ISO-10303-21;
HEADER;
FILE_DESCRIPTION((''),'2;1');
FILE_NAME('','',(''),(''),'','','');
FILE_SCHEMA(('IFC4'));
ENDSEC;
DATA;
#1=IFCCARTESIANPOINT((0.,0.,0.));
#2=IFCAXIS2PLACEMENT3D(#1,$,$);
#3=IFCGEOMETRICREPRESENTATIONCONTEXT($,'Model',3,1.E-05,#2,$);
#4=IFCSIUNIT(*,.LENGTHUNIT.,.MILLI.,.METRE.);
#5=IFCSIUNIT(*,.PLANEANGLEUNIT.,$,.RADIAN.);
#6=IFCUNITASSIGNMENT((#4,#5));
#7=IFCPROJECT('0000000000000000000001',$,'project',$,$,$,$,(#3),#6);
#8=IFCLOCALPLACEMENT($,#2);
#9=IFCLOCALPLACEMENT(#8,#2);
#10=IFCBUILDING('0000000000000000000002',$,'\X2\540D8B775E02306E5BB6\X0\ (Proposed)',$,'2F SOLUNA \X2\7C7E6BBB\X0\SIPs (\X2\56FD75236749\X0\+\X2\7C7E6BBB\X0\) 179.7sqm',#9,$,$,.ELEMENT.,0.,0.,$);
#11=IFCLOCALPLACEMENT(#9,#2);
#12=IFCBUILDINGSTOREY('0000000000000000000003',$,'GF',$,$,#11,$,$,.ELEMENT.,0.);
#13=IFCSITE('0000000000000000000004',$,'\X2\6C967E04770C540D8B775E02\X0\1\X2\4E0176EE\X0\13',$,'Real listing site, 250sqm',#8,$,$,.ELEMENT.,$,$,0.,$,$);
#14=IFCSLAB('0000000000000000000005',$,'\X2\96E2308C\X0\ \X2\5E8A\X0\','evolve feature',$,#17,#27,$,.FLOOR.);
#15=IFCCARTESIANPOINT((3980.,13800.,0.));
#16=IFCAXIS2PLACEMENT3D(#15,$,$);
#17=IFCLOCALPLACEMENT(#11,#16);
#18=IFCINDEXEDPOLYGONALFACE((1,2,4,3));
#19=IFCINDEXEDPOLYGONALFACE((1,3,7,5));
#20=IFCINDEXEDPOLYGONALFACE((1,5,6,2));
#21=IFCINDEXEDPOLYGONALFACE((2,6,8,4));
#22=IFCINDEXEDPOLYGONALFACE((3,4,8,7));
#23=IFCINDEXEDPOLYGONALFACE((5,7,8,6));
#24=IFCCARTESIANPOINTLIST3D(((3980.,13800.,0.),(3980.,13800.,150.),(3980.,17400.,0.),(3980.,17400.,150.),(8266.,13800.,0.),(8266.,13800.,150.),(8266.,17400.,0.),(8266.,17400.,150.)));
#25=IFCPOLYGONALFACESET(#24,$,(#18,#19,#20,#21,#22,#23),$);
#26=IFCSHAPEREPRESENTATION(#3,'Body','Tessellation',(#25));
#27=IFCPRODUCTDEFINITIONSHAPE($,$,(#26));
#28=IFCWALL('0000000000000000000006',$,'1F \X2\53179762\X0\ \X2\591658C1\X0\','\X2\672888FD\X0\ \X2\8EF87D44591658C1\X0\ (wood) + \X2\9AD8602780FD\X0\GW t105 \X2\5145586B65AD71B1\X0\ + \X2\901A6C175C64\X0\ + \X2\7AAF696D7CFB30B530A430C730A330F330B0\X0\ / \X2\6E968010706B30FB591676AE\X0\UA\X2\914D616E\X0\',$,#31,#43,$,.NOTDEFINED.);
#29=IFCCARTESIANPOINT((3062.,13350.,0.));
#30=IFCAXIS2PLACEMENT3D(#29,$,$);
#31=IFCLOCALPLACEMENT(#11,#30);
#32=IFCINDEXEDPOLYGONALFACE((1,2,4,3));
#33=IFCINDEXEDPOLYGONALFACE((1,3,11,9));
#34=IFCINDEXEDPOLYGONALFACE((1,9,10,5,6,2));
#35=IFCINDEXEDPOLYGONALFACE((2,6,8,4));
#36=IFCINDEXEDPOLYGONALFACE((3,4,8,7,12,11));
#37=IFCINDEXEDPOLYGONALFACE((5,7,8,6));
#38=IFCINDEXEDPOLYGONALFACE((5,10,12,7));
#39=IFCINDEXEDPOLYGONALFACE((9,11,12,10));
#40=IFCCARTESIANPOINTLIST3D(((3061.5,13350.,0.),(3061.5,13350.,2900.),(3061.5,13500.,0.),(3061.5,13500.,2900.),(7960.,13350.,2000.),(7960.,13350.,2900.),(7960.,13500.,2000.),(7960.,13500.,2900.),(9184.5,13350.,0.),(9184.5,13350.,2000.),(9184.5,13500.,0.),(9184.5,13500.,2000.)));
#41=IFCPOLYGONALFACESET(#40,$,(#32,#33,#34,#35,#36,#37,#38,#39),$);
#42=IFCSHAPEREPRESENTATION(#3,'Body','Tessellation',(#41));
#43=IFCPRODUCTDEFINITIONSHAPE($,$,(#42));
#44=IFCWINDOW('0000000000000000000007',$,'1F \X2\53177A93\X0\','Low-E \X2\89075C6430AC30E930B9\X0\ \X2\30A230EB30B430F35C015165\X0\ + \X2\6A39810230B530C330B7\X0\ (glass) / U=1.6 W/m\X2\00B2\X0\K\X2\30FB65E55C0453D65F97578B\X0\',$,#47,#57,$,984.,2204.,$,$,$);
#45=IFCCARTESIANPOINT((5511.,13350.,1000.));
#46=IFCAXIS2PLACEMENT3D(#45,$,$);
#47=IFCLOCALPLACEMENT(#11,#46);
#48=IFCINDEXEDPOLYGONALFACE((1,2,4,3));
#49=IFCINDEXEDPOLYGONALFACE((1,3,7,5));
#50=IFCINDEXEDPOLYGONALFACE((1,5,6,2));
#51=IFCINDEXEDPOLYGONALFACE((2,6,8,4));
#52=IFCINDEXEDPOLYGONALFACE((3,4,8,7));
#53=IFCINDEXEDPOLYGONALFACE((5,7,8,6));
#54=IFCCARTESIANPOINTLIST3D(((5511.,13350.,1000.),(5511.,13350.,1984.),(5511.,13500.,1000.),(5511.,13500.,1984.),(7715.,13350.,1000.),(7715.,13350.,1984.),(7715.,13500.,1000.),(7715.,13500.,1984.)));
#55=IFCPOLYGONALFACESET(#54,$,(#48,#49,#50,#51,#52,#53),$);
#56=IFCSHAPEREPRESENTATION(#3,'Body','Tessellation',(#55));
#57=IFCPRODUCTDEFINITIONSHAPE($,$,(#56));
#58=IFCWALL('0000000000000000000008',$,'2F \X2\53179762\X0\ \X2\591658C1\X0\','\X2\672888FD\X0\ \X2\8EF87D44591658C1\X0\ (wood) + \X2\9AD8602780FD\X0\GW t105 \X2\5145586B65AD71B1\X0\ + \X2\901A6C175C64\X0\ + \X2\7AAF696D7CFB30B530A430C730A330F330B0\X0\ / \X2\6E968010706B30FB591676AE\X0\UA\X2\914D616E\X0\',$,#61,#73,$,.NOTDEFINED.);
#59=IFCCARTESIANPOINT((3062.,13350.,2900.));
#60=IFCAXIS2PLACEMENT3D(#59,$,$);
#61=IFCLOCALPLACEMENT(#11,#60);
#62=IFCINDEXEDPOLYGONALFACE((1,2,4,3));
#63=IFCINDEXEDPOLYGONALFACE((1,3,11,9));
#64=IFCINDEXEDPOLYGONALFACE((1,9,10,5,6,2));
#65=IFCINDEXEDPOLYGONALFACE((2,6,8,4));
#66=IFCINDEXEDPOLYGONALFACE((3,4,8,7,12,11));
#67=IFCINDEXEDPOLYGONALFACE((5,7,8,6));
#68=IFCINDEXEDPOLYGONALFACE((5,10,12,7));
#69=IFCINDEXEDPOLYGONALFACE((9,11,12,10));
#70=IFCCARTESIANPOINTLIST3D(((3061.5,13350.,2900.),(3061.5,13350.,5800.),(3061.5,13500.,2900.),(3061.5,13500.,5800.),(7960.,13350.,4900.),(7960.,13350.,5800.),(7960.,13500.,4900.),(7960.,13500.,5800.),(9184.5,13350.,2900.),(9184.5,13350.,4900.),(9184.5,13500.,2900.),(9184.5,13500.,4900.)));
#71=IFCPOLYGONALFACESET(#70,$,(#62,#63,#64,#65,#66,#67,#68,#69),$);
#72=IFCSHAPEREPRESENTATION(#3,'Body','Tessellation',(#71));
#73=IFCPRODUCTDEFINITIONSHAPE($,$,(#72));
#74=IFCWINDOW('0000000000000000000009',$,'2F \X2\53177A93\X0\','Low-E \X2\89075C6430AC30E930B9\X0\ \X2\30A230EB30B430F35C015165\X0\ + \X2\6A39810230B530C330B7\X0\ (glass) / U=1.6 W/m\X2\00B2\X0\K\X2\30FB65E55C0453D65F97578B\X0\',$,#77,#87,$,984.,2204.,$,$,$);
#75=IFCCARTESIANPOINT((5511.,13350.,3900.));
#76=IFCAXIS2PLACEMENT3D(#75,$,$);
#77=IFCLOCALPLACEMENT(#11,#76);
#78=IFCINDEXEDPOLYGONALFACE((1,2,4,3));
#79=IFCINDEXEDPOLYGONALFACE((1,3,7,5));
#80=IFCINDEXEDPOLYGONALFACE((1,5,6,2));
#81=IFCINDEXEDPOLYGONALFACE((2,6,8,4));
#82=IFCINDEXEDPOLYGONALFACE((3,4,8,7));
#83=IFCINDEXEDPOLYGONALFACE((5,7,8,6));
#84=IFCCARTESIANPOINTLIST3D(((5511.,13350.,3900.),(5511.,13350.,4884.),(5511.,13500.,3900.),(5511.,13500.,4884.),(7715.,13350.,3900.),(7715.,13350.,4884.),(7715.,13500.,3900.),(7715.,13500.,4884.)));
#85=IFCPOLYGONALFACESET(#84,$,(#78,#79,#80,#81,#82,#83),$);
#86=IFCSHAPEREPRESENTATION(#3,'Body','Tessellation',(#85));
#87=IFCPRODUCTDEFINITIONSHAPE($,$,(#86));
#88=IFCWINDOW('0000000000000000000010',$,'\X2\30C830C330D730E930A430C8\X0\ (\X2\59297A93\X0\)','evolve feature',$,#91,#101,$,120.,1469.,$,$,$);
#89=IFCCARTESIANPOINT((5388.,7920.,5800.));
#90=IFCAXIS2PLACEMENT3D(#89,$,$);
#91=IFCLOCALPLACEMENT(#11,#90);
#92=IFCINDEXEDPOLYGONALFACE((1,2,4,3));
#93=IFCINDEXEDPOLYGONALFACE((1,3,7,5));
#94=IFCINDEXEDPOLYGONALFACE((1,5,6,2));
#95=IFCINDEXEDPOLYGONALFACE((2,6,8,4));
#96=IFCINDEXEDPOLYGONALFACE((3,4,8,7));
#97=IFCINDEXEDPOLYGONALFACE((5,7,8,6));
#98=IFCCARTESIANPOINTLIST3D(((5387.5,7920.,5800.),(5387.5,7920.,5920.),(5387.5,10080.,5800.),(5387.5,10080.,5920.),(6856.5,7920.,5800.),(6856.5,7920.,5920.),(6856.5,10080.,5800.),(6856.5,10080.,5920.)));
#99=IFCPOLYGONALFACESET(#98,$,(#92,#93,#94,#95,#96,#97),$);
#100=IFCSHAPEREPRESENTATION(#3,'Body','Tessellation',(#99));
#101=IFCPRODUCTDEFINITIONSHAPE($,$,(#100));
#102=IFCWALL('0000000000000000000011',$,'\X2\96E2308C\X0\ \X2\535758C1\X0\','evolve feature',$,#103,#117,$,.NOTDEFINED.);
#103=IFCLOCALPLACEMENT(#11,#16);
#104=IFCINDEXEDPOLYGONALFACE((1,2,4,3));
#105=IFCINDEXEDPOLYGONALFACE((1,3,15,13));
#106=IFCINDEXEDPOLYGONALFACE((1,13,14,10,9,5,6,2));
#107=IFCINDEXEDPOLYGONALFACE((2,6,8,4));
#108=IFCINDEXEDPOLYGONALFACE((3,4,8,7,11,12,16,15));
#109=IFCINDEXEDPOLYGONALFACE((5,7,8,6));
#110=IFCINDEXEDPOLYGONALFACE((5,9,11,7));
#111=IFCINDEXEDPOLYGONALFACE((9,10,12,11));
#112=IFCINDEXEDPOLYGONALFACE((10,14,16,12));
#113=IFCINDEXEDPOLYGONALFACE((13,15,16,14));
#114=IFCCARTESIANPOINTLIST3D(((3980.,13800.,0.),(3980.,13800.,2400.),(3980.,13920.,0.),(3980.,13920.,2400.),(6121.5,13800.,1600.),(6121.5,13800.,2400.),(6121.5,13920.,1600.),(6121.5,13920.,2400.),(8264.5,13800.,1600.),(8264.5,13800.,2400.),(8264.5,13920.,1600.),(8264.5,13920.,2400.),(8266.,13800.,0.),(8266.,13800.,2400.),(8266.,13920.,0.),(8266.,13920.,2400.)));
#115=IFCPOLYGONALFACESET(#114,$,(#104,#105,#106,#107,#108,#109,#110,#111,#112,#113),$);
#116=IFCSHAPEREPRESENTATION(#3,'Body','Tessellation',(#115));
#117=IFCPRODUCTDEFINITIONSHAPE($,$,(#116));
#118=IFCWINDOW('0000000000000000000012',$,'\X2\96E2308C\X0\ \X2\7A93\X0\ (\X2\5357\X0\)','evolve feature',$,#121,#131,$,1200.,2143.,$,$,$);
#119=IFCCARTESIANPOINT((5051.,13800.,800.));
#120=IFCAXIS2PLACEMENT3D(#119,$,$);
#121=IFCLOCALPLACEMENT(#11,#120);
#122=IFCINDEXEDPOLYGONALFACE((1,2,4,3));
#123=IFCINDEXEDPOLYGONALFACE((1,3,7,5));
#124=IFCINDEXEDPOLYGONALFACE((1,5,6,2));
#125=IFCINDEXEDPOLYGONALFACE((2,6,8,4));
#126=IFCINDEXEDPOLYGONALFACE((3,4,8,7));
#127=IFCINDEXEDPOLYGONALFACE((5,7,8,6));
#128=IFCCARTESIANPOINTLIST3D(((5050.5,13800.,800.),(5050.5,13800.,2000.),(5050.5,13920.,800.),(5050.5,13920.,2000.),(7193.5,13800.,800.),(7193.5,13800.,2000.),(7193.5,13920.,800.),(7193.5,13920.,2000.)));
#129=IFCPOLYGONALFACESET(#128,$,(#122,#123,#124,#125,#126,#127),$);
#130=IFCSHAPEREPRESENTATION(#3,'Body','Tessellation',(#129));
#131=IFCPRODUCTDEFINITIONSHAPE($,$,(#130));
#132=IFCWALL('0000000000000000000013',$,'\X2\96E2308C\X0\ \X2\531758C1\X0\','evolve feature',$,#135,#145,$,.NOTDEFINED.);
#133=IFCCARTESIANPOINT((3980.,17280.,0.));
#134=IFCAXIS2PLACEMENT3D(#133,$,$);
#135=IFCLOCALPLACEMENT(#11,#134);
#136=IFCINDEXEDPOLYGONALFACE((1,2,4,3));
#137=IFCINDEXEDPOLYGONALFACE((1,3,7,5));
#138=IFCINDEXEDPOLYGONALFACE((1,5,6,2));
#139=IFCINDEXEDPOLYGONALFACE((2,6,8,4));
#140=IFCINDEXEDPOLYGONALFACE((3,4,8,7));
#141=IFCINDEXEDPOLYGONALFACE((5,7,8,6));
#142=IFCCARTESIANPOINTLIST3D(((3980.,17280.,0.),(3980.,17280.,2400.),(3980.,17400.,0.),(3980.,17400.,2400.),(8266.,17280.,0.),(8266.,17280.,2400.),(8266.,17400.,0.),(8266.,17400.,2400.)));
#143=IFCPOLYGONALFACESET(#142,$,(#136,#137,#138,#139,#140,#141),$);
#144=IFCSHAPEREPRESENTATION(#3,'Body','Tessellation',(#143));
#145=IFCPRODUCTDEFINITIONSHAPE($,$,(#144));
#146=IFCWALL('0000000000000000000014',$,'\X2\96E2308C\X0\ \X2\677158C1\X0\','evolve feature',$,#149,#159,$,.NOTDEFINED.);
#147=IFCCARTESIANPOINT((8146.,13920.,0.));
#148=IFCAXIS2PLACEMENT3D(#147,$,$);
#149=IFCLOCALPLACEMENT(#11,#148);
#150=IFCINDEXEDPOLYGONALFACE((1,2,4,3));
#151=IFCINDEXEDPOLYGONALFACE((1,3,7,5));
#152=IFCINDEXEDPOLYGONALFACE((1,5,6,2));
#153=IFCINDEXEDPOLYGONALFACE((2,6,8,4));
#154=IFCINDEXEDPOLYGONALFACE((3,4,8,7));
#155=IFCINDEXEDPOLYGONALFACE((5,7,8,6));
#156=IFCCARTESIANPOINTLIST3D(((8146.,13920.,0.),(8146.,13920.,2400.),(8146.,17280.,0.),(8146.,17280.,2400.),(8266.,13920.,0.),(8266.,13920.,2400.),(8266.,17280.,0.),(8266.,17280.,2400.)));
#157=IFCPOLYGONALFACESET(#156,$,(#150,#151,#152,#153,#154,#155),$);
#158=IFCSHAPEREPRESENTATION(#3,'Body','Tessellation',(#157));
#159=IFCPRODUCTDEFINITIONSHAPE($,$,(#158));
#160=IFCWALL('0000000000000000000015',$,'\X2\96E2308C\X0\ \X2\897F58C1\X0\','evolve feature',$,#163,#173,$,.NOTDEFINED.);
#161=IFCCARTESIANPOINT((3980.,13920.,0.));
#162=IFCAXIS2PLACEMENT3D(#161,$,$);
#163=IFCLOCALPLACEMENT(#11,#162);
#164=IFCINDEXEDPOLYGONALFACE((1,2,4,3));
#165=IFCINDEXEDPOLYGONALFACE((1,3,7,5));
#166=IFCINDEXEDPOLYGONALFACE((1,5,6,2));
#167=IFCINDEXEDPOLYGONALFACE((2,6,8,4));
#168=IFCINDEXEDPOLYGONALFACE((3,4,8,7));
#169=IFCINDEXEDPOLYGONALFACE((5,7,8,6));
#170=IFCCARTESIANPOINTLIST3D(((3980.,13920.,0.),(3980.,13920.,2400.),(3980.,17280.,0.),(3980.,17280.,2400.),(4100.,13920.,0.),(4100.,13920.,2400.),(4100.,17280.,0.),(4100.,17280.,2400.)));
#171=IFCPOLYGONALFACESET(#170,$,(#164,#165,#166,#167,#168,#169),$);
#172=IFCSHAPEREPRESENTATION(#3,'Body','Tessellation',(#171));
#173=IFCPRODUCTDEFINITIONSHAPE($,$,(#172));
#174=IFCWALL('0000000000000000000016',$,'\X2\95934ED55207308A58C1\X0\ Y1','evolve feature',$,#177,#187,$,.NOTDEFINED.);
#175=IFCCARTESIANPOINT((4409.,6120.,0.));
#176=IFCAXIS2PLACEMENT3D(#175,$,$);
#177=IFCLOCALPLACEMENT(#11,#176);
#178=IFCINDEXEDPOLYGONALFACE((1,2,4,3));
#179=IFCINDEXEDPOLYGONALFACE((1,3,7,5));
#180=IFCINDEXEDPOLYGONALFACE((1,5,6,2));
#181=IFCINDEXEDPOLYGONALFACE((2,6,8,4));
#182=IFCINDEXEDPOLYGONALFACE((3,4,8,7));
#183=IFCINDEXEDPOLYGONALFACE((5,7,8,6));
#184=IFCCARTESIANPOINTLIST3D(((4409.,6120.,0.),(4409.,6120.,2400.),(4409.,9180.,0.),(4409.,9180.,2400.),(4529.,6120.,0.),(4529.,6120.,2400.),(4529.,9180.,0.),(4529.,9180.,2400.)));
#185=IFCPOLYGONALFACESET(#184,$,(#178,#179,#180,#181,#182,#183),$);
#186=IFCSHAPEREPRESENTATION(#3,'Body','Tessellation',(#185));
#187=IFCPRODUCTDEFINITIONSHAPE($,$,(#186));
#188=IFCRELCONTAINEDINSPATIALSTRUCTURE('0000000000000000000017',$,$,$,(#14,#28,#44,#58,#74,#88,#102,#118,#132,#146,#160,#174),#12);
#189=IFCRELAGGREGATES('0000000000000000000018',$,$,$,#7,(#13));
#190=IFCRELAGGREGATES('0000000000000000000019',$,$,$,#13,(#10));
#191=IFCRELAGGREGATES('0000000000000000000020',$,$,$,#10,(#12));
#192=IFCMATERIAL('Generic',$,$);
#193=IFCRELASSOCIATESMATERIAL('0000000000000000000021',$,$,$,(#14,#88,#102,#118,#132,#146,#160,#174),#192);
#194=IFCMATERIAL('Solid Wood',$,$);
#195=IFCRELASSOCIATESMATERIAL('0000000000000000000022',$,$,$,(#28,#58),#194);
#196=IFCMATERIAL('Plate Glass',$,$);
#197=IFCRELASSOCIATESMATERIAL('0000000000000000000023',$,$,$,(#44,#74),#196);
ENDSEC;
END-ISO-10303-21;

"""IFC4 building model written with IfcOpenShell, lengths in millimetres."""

from ifc_helpers import new_model, si_unit, frame, frame_2d, origin, place, context, project, spatial, rectangle, extrude, material, element, fill, save


model = new_model("IFC4")

# Units and contexts
model_context = context("Model", 3, precision=1e-05, world=origin())
ifc_project = project(units=[si_unit("LENGTHUNIT", "METRE", prefix="MILLI"), si_unit("PLANEANGLEUNIT", "RADIAN")], contexts=[model_context])

# Site, building, storey
site_placement = place(None, origin())
site = spatial("IfcSite", under=ifc_project, at=site_placement, Name="沖縄県名護市1丁目13", ObjectType="Real listing site, 250sqm", CompositionType="ELEMENT", RefElevation=0.0)
building_placement = place(site_placement, origin())
building = spatial("IfcBuilding", under=site, at=building_placement, Name="名護市の家 (Proposed)", ObjectType="2F SOLUNA 籾殻SIPs (国産杉+籾殻) 179.7sqm", CompositionType="ELEMENT", ElevationOfRefHeight=0.0, ElevationOfTerrain=0.0)
storey_placement = place(building_placement, origin())
storey = spatial("IfcBuildingStorey", under=building, at=storey_placement, Name="GF", CompositionType="ELEMENT", Elevation=0.0)

# Slab
ifc_material_1 = material(Name="Generic")
slab_placement = place(storey_placement, frame((3980.0, 13800.0, 0.0)))
element("IfcSlab", 1, at=slab_placement, inside=storey, material=ifc_material_1, Name="離れ 床", Description="evolve feature", PredefinedType="FLOOR", context=model_context, shape_type="SweptSolid", body=[
    extrude(rectangle(XDim=4286.0, YDim=3600.0, at=frame_2d((2143.0, 1800.0))), frame((3980.0, 13800.0, 0.0)), (0.0, 0.0, 1.0), 150.0),
])

# Wall, opening, window
ifc_material_2 = material(Name="Solid Wood")
wall_1_placement = place(storey_placement, frame((3062.0, 13350.0, 0.0)))
wall_1 = element("IfcWall", 2, at=wall_1_placement, inside=storey, material=ifc_material_2, Name="1F 北面 外壁", Description="木製 軸組外壁 (wood) + 高性能GW t105 充填断熱 + 通気層 + 窯業系サイディング / 準耐火・外皮UA配慮", PredefinedType="NOTDEFINED", context=model_context, shape_type="SweptSolid", body=[
    extrude(rectangle(XDim=6123.0, YDim=150.0, at=frame_2d((3061.0, 75.0))), frame((3062.0, 13350.0, 0.0)), (0.0, 0.0, 1.0), 2900.0),
])
opening_1_placement = place(storey_placement, frame((5511.0, 13350.0, 1000.0)))
opening_1 = element("IfcOpeningElement", 3, at=opening_1_placement, cuts=wall_1, PredefinedType="NOTDEFINED", context=model_context, shape_type="SweptSolid", body=[
    extrude(rectangle(XDim=2204.0, YDim=150.0, at=frame_2d((1102.0, 75.0))), frame((5511.0, 13350.0, 1000.0)), (0.0, 0.0, 1.0), 984.0),
])
ifc_material_3 = material(Name="Plate Glass")
window_1_placement = place(storey_placement, frame((5511.0, 13350.0, 1000.0)))
window_1 = element("IfcWindow", 4, at=window_1_placement, inside=storey, material=ifc_material_3, Name="1F 北窓", Description="Low-E 複層ガラス アルゴン封入 + 樹脂サッシ (glass) / U=1.6 W/m²K・日射取得型", OverallHeight=984.0, OverallWidth=2204.0, context=model_context, shape_type="SweptSolid", body=[
    extrude(rectangle(XDim=2204.0, YDim=150.0, at=frame_2d((1102.0, 75.0))), frame((5511.0, 13350.0, 1000.0)), (0.0, 0.0, 1.0), 984.0),
])
fill(opening_1, window_1)

# Wall, opening, window
wall_2_placement = place(storey_placement, frame((3062.0, 13350.0, 2900.0)))
wall_2 = element("IfcWall", 5, at=wall_2_placement, inside=storey, material=ifc_material_2, Name="2F 北面 外壁", Description="木製 軸組外壁 (wood) + 高性能GW t105 充填断熱 + 通気層 + 窯業系サイディング / 準耐火・外皮UA配慮", PredefinedType="NOTDEFINED", context=model_context, shape_type="SweptSolid", body=[
    extrude(rectangle(XDim=6123.0, YDim=150.0, at=frame_2d((3061.0, 75.0))), frame((3062.0, 13350.0, 2900.0)), (0.0, 0.0, 1.0), 2900.0),
])
opening_2_placement = place(storey_placement, frame((5511.0, 13350.0, 3900.0)))
opening_2 = element("IfcOpeningElement", 6, at=opening_2_placement, cuts=wall_2, PredefinedType="NOTDEFINED", context=model_context, shape_type="SweptSolid", body=[
    extrude(rectangle(XDim=2204.0, YDim=150.0, at=frame_2d((1102.0, 75.0))), frame((5511.0, 13350.0, 3900.0)), (0.0, 0.0, 1.0), 984.0),
])
window_2_placement = place(storey_placement, frame((5511.0, 13350.0, 3900.0)))
window_2 = element("IfcWindow", 7, at=window_2_placement, inside=storey, material=ifc_material_3, Name="2F 北窓", Description="Low-E 複層ガラス アルゴン封入 + 樹脂サッシ (glass) / U=1.6 W/m²K・日射取得型", OverallHeight=984.0, OverallWidth=2204.0, context=model_context, shape_type="SweptSolid", body=[
    extrude(rectangle(XDim=2204.0, YDim=150.0, at=frame_2d((1102.0, 75.0))), frame((5511.0, 13350.0, 3900.0)), (0.0, 0.0, 1.0), 984.0),
])
fill(opening_2, window_2)

# Window
window_3_placement = place(storey_placement, frame((5388.0, 7920.0, 5800.0)))
element("IfcWindow", 8, at=window_3_placement, inside=storey, material=ifc_material_1, Name="トップライト (天窓)", Description="evolve feature", OverallHeight=120.0, OverallWidth=1469.0, context=model_context, shape_type="SweptSolid", body=[
    extrude(rectangle(XDim=1469.0, YDim=2160.0, at=frame_2d((734.0, 1080.0))), frame((5388.0, 7920.0, 5800.0)), (0.0, 0.0, 1.0), 120.0),
])

# Wall, opening, window
wall_3_placement = place(storey_placement, frame((3980.0, 13800.0, 0.0)))
wall_3 = element("IfcWall", 9, at=wall_3_placement, inside=storey, material=ifc_material_1, Name="離れ 南壁", Description="evolve feature", PredefinedType="NOTDEFINED", context=model_context, shape_type="SweptSolid", body=[
    extrude(rectangle(XDim=4286.0, YDim=120.0, at=frame_2d((2143.0, 60.0))), frame((3980.0, 13800.0, 0.0)), (0.0, 0.0, 1.0), 2400.0),
])
opening_3_placement = place(storey_placement, frame((5051.0, 13800.0, 800.0)))
opening_3 = element("IfcOpeningElement", 10, at=opening_3_placement, cuts=wall_3, PredefinedType="NOTDEFINED", context=model_context, shape_type="SweptSolid", body=[
    extrude(rectangle(XDim=2143.0, YDim=120.0, at=frame_2d((1071.0, 60.0))), frame((5051.0, 13800.0, 800.0)), (0.0, 0.0, 1.0), 1200.0),
])
window_4_placement = place(storey_placement, frame((5051.0, 13800.0, 800.0)))
window_4 = element("IfcWindow", 11, at=window_4_placement, inside=storey, material=ifc_material_1, Name="離れ 窓 (南)", Description="evolve feature", OverallHeight=1200.0, OverallWidth=2143.0, context=model_context, shape_type="SweptSolid", body=[
    extrude(rectangle(XDim=2143.0, YDim=120.0, at=frame_2d((1071.0, 60.0))), frame((5051.0, 13800.0, 800.0)), (0.0, 0.0, 1.0), 1200.0),
])
fill(opening_3, window_4)

# Walls
wall_4_placement = place(storey_placement, frame((3980.0, 17280.0, 0.0)))
element("IfcWall", 12, at=wall_4_placement, inside=storey, material=ifc_material_1, Name="離れ 北壁", Description="evolve feature", PredefinedType="NOTDEFINED", context=model_context, shape_type="SweptSolid", body=[
    extrude(rectangle(XDim=4286.0, YDim=120.0, at=frame_2d((2143.0, 60.0))), frame((3980.0, 17280.0, 0.0)), (0.0, 0.0, 1.0), 2400.0),
])
wall_5_placement = place(storey_placement, frame((8146.0, 13920.0, 0.0)))
element("IfcWall", 13, at=wall_5_placement, inside=storey, material=ifc_material_1, Name="離れ 東壁", Description="evolve feature", PredefinedType="NOTDEFINED", context=model_context, shape_type="SweptSolid", body=[
    extrude(rectangle(XDim=120.0, YDim=3360.0, at=frame_2d((60.0, 1680.0))), frame((8146.0, 13920.0, 0.0)), (0.0, 0.0, 1.0), 2400.0),
])
wall_6_placement = place(storey_placement, frame((3980.0, 13920.0, 0.0)))
element("IfcWall", 14, at=wall_6_placement, inside=storey, material=ifc_material_1, Name="離れ 西壁", Description="evolve feature", PredefinedType="NOTDEFINED", context=model_context, shape_type="SweptSolid", body=[
    extrude(rectangle(XDim=120.0, YDim=3360.0, at=frame_2d((60.0, 1680.0))), frame((3980.0, 13920.0, 0.0)), (0.0, 0.0, 1.0), 2400.0),
])
wall_7_placement = place(storey_placement, frame((4409.0, 6120.0, 0.0)))
element("IfcWall", 15, at=wall_7_placement, inside=storey, material=ifc_material_1, Name="間仕切り壁 Y1", Description="evolve feature", PredefinedType="NOTDEFINED", context=model_context, shape_type="SweptSolid", body=[
    extrude(rectangle(XDim=120.0, YDim=3060.0, at=frame_2d((60.0, 1530.0))), frame((4409.0, 6120.0, 0.0)), (0.0, 0.0, 1.0), 2400.0),
])

save(model, "model.ifc")
